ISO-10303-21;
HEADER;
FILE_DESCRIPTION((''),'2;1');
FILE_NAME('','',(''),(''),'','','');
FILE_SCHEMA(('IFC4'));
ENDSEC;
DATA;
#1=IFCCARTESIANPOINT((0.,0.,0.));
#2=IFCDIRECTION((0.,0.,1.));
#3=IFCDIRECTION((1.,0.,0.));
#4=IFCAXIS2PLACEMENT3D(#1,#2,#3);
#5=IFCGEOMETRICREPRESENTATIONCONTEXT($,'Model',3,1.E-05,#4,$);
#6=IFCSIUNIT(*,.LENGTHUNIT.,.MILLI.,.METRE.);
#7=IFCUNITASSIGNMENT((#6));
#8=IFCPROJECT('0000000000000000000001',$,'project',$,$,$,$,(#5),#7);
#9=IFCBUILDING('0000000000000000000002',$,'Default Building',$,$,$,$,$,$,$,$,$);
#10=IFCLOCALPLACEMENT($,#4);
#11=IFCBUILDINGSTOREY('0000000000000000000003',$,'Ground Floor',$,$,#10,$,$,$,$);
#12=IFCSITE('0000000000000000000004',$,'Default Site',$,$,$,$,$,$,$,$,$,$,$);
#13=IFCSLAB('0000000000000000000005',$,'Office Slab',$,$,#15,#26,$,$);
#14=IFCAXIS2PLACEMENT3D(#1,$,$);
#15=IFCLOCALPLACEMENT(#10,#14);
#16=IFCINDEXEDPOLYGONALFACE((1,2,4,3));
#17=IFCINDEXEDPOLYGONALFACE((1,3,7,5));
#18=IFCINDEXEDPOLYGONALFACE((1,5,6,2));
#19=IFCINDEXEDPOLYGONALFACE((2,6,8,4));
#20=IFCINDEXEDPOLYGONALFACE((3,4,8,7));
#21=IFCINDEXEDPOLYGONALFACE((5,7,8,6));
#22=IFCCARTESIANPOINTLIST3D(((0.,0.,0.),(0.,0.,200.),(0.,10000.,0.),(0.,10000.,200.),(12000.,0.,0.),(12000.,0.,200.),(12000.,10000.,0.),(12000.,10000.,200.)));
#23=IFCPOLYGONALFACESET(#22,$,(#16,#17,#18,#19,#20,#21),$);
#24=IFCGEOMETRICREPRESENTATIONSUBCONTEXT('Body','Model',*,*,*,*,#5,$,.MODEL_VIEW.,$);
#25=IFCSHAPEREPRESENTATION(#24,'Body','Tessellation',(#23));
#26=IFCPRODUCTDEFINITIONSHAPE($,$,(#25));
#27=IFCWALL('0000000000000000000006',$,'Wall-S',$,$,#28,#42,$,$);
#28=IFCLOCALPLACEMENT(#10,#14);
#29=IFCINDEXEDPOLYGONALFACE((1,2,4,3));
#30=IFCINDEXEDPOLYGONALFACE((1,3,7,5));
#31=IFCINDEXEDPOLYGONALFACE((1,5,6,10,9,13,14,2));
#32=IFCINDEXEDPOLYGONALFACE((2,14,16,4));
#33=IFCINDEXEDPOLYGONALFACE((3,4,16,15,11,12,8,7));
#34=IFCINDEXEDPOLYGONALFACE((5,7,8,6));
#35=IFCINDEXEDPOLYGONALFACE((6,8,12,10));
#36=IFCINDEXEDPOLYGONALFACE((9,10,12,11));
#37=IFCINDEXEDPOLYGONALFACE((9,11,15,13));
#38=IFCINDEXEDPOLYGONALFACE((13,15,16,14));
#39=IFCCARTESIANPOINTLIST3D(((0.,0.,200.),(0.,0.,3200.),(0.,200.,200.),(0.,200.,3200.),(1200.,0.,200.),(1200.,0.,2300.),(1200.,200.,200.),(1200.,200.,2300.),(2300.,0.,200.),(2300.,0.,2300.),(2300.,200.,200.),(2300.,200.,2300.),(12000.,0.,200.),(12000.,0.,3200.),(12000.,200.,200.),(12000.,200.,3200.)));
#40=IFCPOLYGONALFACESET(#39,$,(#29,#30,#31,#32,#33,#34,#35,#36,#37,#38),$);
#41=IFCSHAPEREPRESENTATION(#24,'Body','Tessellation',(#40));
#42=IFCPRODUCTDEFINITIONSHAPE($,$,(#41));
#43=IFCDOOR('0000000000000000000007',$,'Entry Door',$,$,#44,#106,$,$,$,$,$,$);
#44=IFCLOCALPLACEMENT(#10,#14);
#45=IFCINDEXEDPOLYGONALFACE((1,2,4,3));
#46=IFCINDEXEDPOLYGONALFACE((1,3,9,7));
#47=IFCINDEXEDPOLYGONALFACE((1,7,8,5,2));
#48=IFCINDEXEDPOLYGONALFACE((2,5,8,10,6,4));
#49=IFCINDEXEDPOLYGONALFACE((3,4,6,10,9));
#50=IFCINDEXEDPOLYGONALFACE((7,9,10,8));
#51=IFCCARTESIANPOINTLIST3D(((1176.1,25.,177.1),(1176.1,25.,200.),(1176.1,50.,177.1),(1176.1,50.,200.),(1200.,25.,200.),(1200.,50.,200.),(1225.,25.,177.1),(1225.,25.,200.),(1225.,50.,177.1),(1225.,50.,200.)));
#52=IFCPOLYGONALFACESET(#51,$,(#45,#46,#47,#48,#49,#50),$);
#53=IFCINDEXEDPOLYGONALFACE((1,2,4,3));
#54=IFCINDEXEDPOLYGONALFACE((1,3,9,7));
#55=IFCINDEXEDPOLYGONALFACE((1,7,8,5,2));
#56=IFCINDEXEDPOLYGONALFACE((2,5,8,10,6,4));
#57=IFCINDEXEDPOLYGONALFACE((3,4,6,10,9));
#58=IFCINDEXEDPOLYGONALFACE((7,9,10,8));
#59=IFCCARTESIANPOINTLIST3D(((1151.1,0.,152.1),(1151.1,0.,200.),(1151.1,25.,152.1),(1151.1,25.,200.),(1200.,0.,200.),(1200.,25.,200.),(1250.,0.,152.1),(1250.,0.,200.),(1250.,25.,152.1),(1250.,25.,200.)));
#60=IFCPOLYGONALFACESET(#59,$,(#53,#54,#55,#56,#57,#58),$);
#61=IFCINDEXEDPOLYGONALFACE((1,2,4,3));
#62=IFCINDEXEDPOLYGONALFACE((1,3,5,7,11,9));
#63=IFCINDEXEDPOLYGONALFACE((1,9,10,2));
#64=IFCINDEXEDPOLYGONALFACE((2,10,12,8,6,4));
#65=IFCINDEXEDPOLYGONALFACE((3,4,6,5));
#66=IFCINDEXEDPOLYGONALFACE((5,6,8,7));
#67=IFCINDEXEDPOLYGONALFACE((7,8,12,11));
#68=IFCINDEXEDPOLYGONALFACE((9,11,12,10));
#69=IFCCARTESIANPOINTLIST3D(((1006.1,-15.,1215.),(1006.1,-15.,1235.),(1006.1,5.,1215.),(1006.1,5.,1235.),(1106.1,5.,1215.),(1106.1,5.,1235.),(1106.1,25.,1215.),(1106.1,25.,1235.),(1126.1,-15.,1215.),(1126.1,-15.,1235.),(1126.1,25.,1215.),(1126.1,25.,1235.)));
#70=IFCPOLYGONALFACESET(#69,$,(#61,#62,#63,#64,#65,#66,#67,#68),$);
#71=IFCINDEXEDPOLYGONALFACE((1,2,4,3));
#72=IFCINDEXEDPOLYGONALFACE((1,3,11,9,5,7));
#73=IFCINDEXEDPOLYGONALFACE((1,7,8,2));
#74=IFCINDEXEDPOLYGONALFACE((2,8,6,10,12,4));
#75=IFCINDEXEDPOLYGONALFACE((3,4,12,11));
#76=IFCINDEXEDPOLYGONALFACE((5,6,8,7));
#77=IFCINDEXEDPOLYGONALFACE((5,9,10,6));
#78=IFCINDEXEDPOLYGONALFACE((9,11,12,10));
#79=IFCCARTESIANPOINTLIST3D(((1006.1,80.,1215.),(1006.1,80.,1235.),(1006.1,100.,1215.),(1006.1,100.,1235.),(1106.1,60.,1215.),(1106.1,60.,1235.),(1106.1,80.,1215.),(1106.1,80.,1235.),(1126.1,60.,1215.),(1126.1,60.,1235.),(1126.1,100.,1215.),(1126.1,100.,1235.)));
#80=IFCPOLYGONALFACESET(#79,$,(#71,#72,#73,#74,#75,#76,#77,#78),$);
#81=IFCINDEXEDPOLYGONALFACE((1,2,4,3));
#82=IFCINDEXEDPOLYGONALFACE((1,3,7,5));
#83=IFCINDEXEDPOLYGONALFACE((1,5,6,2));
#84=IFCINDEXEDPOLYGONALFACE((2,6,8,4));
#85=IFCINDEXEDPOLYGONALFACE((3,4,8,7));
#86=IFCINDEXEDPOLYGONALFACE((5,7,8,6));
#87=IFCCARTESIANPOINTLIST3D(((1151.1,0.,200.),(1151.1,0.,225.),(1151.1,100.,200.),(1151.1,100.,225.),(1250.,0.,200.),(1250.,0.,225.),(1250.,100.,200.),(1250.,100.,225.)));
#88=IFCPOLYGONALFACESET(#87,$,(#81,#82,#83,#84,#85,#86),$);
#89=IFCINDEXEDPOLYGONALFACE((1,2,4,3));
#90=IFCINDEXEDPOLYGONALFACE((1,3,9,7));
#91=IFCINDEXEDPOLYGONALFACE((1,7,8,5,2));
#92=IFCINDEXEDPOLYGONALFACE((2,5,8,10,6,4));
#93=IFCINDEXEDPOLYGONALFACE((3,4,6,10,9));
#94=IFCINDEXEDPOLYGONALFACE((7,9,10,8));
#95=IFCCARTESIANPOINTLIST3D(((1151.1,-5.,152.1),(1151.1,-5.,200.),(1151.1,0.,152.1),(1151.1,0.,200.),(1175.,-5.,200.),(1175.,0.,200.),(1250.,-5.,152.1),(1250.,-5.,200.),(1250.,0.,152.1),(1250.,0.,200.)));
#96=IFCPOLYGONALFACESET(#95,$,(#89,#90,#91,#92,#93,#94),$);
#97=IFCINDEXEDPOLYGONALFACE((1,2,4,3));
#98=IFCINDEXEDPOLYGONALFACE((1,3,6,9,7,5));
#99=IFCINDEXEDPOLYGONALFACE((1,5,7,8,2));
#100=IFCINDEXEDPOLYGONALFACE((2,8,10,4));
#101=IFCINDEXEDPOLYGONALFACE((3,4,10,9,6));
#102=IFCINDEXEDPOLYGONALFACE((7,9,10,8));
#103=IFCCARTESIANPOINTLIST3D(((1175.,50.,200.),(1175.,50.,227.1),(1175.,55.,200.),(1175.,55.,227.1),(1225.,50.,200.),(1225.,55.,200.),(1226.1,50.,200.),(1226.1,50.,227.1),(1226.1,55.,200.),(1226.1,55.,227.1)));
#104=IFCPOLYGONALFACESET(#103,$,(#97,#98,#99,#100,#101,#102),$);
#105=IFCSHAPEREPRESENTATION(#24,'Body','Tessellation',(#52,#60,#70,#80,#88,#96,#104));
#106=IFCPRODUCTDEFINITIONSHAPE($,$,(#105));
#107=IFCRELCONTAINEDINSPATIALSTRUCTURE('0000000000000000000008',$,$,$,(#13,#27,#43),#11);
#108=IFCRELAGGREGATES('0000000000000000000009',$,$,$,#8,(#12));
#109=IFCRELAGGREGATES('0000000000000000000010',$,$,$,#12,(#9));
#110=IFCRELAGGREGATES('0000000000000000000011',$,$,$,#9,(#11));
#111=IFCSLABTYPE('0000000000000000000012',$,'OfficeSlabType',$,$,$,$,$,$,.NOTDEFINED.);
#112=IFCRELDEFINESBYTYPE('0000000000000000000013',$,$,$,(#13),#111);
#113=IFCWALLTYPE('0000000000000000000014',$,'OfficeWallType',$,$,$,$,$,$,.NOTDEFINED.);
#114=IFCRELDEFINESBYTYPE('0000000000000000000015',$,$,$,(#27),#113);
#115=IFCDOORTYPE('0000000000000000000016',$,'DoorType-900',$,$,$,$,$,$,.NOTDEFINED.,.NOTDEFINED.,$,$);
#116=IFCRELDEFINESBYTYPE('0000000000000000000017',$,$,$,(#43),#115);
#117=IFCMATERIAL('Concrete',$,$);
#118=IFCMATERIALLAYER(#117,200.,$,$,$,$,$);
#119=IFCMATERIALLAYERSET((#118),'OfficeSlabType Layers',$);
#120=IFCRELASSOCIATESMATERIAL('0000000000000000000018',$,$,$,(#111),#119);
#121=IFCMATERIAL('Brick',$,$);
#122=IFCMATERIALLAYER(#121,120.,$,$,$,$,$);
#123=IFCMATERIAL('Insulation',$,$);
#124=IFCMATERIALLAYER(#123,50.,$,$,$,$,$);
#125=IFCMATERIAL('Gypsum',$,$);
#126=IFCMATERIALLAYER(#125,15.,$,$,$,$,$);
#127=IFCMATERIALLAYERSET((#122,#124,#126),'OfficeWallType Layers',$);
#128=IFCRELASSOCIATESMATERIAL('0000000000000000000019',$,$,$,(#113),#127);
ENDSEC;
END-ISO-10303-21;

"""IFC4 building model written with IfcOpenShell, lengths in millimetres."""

from ifc_helpers import new_model, si_unit, frame, origin_with_axes, place, context, subcontext, project, spatial, line, indexed_curve, outline, extrude, material, layer, layer_set, type_object, element, fill, save


model = new_model("IFC4")

# Units and contexts
model_context = context("Model", 3, precision=1e-05, world=origin_with_axes())
body_context = subcontext(model_context, "Body", "Model", "MODEL_VIEW")
ifc_project = project(units=[si_unit("LENGTHUNIT", "METRE", prefix="MILLI")], contexts=[model_context])

# Site, building, storey
site = spatial("IfcSite", under=ifc_project, Name="Default Site")
building = spatial("IfcBuilding", under=site, Name="Default Building")
storey_placement = place(None, origin_with_axes())
storey = spatial("IfcBuildingStorey", under=building, at=storey_placement, Name="Ground Floor")

# Slab
ifc_material_1 = material(Name="Concrete")
ifc_layer_1 = layer(ifc_material_1, 200.0)
ifc_layer_set_1 = layer_set([ifc_layer_1], Name="OfficeSlabType Layers")
slab_type = type_object("IfcSlabType", Name="OfficeSlabType", PredefinedType="NOTDEFINED", material=ifc_layer_set_1)
slab_placement = place(storey_placement, origin_with_axes())
element("IfcSlab", 1, at=slab_placement, inside=storey, type_object=slab_type, Name="Office Slab", context=body_context, shape_type="SweptSolid", body=[
    extrude(outline(indexed_curve([(0.0, 0.0), (12000.0, 0.0), (12000.0, 10000.0), (0.0, 10000.0), (0.0, 0.0)])), None, (0.0, 0.0, 1.0), 200.0),
])

# Wall, opening, door
ifc_material_2 = material(Name="Brick")
ifc_layer_2 = layer(ifc_material_2, 120.0)
ifc_material_3 = material(Name="Insulation")
ifc_layer_3 = layer(ifc_material_3, 50.0)
ifc_material_4 = material(Name="Gypsum")
ifc_layer_4 = layer(ifc_material_4, 15.0)
ifc_layer_set_2 = layer_set([ifc_layer_2, ifc_layer_3, ifc_layer_4], Name="OfficeWallType Layers")
wall_type = type_object("IfcWallType", Name="OfficeWallType", PredefinedType="NOTDEFINED", material=ifc_layer_set_2)
wall_1_placement = place(storey_placement, frame((0.0, 0.0, 200.0), z_axis=(0.0, 0.0, 1.0), x_axis=(1.0, 0.0, 0.0)))
wall_1 = element("IfcWall", 2, at=wall_1_placement, inside=storey, type_object=wall_type, Name="Wall-S", context=body_context, shape_type="SweptSolid", body=[
    extrude(outline(indexed_curve([(0.0, 0.0), (12000.0, 0.0), (12000.0, 200.0), (0.0, 200.0), (0.0, 0.0)])), None, (0.0, 0.0, 1.0), 3000.0),
])
opening_1_placement = place(wall_1_placement, origin_with_axes())
opening_1 = element("IfcOpeningElement", 3, at=opening_1_placement, cuts=wall_1, context=body_context, shape_type="SweptSolid", body=[
    extrude(outline(indexed_curve([(1200.0, 0.0), (2300.0, 0.0), (2300.0, 200.0), (1200.0, 200.0), (1200.0, 0.0)])), None, (0.0, 0.0, 1.0), 2100.0),
])
door_type = type_object("IfcDoorType", Name="DoorType-900", OperationType="NOTDEFINED", PredefinedType="NOTDEFINED")
door_1_placement = place(storey_placement, frame((1200.0, 0.0, 200.0), z_axis=(0.0, 0.0, 1.0), x_axis=(1.0, 0.0, 0.0)))
door_1 = element("IfcDoor", 4, at=door_1_placement, inside=storey, type_object=door_type, Name="Entry Door", context=body_context, shape_type="SweptSolid", body=[
    extrude(outline(indexed_curve([(0.0, 0.0), (0.0, 2.1), (1.1, 2.1), (1.1, 0.0), (-23.9, 0.0), (-23.9, -22.9), (25.0, -22.9), (25.0, 0.0)], segments=[line(1, 2, 3, 4, 5, 6, 7, 8, 1)])), frame((0.0, 25.0, 0.0), z_axis=(0.0, -1.0, 0.0), x_axis=(1.0, 0.0, 0.0)), (0.0, 0.0, -1.0), 25.0),
    extrude(outline(indexed_curve([(0.0, 0.0), (0.0, 2.1), (1.1, 2.1), (1.1, 0.0), (-48.9, 0.0), (-48.9, -47.9), (50.0, -47.9), (50.0, 0.0)], segments=[line(1, 2, 3, 4, 5, 6, 7, 8, 1)])), frame((0.0, 0.0, 0.0), z_axis=(0.0, -1.0, 0.0), x_axis=(1.0, 0.0, 0.0)), (0.0, 0.0, -1.0), 25.0),
    extrude(outline(indexed_curve([(0.0, 0.0), (-48.9, 0.0), (-48.9, 35.0), (0.0, 35.0)], segments=[line(1, 2, 3, 4, 1)])), frame((25.0, 25.0, 25.0), z_axis=(0.0, 0.0, 1.0), x_axis=(1.0, 0.0, 0.0)), (0.0, 0.0, 1.0), -47.9),
    extrude(outline(indexed_curve([(0.0, 0.0), (0.0, -40.0), (-120.0, -40.0), (-120.0, -20.0), (-20.0, -20.0), (-20.0, 0.0)], segments=[line(1, 2, 3, 4, 5, 6, 1)])), frame((-73.9, 25.0, 1015.0), z_axis=(0.0, 0.0, 1.0), x_axis=(1.0, 0.0, 0.0)), (0.0, 0.0, 1.0), 20.0),
    extrude(outline(indexed_curve([(0.0, 0.0), (0.0, 40.0), (-120.0, 40.0), (-120.0, 20.0), (-20.0, 20.0), (-20.0, 0.0)], segments=[line(1, 2, 3, 4, 5, 6, 1)])), frame((-73.9, 60.0, 1015.0), z_axis=(0.0, 0.0, 1.0), x_axis=(1.0, 0.0, 0.0)), (0.0, 0.0, 1.0), 20.0),
    extrude(outline(indexed_curve([(0.0, 0.0), (-98.9, 0.0), (-98.9, 100.0), (0.0, 100.0)], segments=[line(1, 2, 3, 4, 1)])), frame((50.0, 0.0, 0.0), z_axis=(0.0, 0.0, 1.0), x_axis=(1.0, 0.0, 0.0)), (0.0, 0.0, 1.0), 25.0),
    extrude(outline(indexed_curve([(0.0, 0.0), (0.0, 27.1), (51.1, 27.1), (51.1, 0.0), (-23.9, 0.0), (-23.9, -47.9), (75.0, -47.9), (75.0, 0.0)], segments=[line(1, 2, 3, 4, 5, 6, 7, 8, 1)])), frame((-25.0, -5.0, 0.0), z_axis=(0.0, -1.0, 0.0), x_axis=(1.0, 0.0, 0.0)), (0.0, 0.0, -1.0), 5.0),
    extrude(outline(indexed_curve([(0.0, 0.0), (0.0, 27.1), (51.1, 27.1), (51.1, 0.0), (1.1, 0.0), (1.1, -22.9), (50.0, -22.9), (50.0, 0.0)], segments=[line(1, 2, 3, 4, 5, 6, 7, 8, 1)])), frame((-25.0, 50.0, 0.0), z_axis=(0.0, -1.0, 0.0), x_axis=(1.0, 0.0, 0.0)), (0.0, 0.0, -1.0), 5.0),
])
fill(opening_1, door_1)

save(model, "model.ifc")
